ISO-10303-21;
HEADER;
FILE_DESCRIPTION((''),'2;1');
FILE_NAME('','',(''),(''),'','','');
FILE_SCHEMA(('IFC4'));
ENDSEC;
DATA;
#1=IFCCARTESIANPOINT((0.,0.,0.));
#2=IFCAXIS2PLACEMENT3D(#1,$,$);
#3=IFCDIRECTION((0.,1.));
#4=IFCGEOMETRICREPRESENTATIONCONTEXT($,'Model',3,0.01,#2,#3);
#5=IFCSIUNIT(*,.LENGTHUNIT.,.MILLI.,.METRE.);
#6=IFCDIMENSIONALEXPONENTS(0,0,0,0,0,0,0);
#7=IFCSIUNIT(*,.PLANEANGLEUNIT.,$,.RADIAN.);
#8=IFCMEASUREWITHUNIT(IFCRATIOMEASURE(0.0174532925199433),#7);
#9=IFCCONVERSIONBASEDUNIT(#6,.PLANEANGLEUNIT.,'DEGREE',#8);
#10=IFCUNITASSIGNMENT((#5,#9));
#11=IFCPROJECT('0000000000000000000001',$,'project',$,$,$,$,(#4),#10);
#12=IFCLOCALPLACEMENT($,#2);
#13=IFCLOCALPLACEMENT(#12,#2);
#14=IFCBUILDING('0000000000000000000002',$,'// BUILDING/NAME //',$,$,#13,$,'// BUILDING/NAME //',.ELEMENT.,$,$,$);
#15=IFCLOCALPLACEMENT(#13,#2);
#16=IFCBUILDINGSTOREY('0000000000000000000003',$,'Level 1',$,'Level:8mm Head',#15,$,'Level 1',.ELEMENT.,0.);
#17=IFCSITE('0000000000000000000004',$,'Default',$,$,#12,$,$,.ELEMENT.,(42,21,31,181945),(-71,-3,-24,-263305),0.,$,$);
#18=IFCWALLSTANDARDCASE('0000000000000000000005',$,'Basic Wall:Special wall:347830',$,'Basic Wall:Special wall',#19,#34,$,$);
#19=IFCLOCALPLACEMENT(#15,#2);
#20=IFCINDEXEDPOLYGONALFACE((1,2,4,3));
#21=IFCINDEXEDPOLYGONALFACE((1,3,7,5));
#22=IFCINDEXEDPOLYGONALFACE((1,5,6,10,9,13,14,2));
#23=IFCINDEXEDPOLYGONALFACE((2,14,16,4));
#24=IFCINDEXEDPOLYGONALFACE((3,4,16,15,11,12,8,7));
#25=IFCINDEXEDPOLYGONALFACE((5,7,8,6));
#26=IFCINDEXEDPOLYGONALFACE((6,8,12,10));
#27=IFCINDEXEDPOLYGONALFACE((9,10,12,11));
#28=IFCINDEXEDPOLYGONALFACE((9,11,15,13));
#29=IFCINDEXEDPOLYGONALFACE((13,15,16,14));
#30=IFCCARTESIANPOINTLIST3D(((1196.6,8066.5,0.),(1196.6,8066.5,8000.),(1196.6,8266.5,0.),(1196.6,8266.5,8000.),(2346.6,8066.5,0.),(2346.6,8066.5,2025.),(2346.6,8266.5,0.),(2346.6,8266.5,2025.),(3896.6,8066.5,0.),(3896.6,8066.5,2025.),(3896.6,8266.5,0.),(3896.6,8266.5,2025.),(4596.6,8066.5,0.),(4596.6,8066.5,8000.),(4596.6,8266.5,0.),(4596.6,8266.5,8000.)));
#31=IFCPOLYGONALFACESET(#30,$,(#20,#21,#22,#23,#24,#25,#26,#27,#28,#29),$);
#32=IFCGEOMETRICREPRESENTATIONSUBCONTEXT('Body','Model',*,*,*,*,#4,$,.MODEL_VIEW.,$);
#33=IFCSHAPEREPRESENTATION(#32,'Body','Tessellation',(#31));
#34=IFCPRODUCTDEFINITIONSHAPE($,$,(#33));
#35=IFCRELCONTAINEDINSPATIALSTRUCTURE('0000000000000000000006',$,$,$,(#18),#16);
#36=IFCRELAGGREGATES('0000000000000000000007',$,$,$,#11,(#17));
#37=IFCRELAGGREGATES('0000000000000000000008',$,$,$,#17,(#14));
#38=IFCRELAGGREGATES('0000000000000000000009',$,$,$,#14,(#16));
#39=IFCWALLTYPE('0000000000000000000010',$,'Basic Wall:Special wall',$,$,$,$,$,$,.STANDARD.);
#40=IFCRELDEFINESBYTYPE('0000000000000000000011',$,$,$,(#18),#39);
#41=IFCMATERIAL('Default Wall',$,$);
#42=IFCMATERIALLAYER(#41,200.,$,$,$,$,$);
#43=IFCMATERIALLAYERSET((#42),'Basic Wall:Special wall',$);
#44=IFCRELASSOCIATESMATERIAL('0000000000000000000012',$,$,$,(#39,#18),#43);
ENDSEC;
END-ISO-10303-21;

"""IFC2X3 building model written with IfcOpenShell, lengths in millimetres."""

from ifc_helpers import new_model, entity, si_unit, converted_unit, direction, frame, frame_2d, origin, place, context, subcontext, project, spatial, rectangle, extrude, material, layer, layer_set, layer_usage, type_object, element, save


model = new_model("IFC2X3")

# Units and contexts
model_context = context("Model", 3, precision=0.01, world=origin(), true_north=direction((0.0, 1.0)))
body_context = subcontext(model_context, "Body", "Model", "MODEL_VIEW")
ifc_project = project(units=[si_unit("LENGTHUNIT", "METRE", prefix="MILLI"), converted_unit("PLANEANGLEUNIT", "DEGREE", entity("IfcRatioMeasure", 0.0174532925199433), si_unit("PLANEANGLEUNIT", "RADIAN"), dimensions=[0, 0, 0, 0, 0, 0, 0])], contexts=[model_context])

# Site, building, storey
site_placement = place(None, origin())
site = spatial("IfcSite", under=ifc_project, at=site_placement, Name="Default", CompositionType="ELEMENT", RefLatitude=(42, 21, 31, 181945), RefLongitude=(-71, -3, -24, -263305), RefElevation=0.0)
building_placement = place(site_placement, origin())
building = spatial("IfcBuilding", under=site, at=building_placement, Name="// BUILDING/NAME //", LongName="// BUILDING/NAME //", CompositionType="ELEMENT")
storey_placement = place(building_placement, origin())
storey = spatial("IfcBuildingStorey", under=building, at=storey_placement, Name="Level 1", ObjectType="Level:8mm Head", LongName="Level 1", CompositionType="ELEMENT", Elevation=0.0)

# Shared definitions
ifc_material_1 = material(Name="Default Wall")
ifc_layer_1 = layer(ifc_material_1, 200.0)
ifc_layer_set_1 = layer_set([ifc_layer_1], Name="Basic Wall:Special wall")
wall_type_1 = type_object("IfcWallType", Name="Basic Wall:Special wall", PredefinedType="STANDARD", material=ifc_layer_set_1)

# Wall, opening
ifc_layer_usage_1 = layer_usage(ifc_layer_set_1, "AXIS2", "NEGATIVE", 100.0)
wall_1_placement = place(storey_placement, frame((1196.6, 8166.5, 0.0)))
wall_1 = element("IfcWallStandardCase", 1, at=wall_1_placement, inside=storey, type_object=wall_type_1, material=ifc_layer_usage_1, Name="Basic Wall:Special wall:347830", ObjectType="Basic Wall:Special wall", context=body_context, shape_type="SweptSolid", body=[
    extrude(rectangle(XDim=3400.0, YDim=200.0, at=frame_2d((1700.0, 0.0), x_axis=(-1.0, 0.0))), origin(), (0.0, 0.0, 1.0), 8000.0),
])
opening_1_placement = place(wall_1_placement, frame((2700.0, 100.0, 0.0)))
element("IfcOpeningElement", 2, at=opening_1_placement, cuts=wall_1, ObjectType="Opening", context=body_context, shape_type="SweptSolid", body=[
    extrude(rectangle(XDim=2025.0, YDim=1550.0, at=frame_2d((1012.5, 775.0), x_axis=(1.0, 0.0))), frame((0.0, 0.0, 0.0), z_axis=(0.0, -1.0, 0.0), x_axis=(0.0, 0.0, 1.0)), (0.0, 0.0, 1.0), 200.0),
])

save(model, "model.ifc")
